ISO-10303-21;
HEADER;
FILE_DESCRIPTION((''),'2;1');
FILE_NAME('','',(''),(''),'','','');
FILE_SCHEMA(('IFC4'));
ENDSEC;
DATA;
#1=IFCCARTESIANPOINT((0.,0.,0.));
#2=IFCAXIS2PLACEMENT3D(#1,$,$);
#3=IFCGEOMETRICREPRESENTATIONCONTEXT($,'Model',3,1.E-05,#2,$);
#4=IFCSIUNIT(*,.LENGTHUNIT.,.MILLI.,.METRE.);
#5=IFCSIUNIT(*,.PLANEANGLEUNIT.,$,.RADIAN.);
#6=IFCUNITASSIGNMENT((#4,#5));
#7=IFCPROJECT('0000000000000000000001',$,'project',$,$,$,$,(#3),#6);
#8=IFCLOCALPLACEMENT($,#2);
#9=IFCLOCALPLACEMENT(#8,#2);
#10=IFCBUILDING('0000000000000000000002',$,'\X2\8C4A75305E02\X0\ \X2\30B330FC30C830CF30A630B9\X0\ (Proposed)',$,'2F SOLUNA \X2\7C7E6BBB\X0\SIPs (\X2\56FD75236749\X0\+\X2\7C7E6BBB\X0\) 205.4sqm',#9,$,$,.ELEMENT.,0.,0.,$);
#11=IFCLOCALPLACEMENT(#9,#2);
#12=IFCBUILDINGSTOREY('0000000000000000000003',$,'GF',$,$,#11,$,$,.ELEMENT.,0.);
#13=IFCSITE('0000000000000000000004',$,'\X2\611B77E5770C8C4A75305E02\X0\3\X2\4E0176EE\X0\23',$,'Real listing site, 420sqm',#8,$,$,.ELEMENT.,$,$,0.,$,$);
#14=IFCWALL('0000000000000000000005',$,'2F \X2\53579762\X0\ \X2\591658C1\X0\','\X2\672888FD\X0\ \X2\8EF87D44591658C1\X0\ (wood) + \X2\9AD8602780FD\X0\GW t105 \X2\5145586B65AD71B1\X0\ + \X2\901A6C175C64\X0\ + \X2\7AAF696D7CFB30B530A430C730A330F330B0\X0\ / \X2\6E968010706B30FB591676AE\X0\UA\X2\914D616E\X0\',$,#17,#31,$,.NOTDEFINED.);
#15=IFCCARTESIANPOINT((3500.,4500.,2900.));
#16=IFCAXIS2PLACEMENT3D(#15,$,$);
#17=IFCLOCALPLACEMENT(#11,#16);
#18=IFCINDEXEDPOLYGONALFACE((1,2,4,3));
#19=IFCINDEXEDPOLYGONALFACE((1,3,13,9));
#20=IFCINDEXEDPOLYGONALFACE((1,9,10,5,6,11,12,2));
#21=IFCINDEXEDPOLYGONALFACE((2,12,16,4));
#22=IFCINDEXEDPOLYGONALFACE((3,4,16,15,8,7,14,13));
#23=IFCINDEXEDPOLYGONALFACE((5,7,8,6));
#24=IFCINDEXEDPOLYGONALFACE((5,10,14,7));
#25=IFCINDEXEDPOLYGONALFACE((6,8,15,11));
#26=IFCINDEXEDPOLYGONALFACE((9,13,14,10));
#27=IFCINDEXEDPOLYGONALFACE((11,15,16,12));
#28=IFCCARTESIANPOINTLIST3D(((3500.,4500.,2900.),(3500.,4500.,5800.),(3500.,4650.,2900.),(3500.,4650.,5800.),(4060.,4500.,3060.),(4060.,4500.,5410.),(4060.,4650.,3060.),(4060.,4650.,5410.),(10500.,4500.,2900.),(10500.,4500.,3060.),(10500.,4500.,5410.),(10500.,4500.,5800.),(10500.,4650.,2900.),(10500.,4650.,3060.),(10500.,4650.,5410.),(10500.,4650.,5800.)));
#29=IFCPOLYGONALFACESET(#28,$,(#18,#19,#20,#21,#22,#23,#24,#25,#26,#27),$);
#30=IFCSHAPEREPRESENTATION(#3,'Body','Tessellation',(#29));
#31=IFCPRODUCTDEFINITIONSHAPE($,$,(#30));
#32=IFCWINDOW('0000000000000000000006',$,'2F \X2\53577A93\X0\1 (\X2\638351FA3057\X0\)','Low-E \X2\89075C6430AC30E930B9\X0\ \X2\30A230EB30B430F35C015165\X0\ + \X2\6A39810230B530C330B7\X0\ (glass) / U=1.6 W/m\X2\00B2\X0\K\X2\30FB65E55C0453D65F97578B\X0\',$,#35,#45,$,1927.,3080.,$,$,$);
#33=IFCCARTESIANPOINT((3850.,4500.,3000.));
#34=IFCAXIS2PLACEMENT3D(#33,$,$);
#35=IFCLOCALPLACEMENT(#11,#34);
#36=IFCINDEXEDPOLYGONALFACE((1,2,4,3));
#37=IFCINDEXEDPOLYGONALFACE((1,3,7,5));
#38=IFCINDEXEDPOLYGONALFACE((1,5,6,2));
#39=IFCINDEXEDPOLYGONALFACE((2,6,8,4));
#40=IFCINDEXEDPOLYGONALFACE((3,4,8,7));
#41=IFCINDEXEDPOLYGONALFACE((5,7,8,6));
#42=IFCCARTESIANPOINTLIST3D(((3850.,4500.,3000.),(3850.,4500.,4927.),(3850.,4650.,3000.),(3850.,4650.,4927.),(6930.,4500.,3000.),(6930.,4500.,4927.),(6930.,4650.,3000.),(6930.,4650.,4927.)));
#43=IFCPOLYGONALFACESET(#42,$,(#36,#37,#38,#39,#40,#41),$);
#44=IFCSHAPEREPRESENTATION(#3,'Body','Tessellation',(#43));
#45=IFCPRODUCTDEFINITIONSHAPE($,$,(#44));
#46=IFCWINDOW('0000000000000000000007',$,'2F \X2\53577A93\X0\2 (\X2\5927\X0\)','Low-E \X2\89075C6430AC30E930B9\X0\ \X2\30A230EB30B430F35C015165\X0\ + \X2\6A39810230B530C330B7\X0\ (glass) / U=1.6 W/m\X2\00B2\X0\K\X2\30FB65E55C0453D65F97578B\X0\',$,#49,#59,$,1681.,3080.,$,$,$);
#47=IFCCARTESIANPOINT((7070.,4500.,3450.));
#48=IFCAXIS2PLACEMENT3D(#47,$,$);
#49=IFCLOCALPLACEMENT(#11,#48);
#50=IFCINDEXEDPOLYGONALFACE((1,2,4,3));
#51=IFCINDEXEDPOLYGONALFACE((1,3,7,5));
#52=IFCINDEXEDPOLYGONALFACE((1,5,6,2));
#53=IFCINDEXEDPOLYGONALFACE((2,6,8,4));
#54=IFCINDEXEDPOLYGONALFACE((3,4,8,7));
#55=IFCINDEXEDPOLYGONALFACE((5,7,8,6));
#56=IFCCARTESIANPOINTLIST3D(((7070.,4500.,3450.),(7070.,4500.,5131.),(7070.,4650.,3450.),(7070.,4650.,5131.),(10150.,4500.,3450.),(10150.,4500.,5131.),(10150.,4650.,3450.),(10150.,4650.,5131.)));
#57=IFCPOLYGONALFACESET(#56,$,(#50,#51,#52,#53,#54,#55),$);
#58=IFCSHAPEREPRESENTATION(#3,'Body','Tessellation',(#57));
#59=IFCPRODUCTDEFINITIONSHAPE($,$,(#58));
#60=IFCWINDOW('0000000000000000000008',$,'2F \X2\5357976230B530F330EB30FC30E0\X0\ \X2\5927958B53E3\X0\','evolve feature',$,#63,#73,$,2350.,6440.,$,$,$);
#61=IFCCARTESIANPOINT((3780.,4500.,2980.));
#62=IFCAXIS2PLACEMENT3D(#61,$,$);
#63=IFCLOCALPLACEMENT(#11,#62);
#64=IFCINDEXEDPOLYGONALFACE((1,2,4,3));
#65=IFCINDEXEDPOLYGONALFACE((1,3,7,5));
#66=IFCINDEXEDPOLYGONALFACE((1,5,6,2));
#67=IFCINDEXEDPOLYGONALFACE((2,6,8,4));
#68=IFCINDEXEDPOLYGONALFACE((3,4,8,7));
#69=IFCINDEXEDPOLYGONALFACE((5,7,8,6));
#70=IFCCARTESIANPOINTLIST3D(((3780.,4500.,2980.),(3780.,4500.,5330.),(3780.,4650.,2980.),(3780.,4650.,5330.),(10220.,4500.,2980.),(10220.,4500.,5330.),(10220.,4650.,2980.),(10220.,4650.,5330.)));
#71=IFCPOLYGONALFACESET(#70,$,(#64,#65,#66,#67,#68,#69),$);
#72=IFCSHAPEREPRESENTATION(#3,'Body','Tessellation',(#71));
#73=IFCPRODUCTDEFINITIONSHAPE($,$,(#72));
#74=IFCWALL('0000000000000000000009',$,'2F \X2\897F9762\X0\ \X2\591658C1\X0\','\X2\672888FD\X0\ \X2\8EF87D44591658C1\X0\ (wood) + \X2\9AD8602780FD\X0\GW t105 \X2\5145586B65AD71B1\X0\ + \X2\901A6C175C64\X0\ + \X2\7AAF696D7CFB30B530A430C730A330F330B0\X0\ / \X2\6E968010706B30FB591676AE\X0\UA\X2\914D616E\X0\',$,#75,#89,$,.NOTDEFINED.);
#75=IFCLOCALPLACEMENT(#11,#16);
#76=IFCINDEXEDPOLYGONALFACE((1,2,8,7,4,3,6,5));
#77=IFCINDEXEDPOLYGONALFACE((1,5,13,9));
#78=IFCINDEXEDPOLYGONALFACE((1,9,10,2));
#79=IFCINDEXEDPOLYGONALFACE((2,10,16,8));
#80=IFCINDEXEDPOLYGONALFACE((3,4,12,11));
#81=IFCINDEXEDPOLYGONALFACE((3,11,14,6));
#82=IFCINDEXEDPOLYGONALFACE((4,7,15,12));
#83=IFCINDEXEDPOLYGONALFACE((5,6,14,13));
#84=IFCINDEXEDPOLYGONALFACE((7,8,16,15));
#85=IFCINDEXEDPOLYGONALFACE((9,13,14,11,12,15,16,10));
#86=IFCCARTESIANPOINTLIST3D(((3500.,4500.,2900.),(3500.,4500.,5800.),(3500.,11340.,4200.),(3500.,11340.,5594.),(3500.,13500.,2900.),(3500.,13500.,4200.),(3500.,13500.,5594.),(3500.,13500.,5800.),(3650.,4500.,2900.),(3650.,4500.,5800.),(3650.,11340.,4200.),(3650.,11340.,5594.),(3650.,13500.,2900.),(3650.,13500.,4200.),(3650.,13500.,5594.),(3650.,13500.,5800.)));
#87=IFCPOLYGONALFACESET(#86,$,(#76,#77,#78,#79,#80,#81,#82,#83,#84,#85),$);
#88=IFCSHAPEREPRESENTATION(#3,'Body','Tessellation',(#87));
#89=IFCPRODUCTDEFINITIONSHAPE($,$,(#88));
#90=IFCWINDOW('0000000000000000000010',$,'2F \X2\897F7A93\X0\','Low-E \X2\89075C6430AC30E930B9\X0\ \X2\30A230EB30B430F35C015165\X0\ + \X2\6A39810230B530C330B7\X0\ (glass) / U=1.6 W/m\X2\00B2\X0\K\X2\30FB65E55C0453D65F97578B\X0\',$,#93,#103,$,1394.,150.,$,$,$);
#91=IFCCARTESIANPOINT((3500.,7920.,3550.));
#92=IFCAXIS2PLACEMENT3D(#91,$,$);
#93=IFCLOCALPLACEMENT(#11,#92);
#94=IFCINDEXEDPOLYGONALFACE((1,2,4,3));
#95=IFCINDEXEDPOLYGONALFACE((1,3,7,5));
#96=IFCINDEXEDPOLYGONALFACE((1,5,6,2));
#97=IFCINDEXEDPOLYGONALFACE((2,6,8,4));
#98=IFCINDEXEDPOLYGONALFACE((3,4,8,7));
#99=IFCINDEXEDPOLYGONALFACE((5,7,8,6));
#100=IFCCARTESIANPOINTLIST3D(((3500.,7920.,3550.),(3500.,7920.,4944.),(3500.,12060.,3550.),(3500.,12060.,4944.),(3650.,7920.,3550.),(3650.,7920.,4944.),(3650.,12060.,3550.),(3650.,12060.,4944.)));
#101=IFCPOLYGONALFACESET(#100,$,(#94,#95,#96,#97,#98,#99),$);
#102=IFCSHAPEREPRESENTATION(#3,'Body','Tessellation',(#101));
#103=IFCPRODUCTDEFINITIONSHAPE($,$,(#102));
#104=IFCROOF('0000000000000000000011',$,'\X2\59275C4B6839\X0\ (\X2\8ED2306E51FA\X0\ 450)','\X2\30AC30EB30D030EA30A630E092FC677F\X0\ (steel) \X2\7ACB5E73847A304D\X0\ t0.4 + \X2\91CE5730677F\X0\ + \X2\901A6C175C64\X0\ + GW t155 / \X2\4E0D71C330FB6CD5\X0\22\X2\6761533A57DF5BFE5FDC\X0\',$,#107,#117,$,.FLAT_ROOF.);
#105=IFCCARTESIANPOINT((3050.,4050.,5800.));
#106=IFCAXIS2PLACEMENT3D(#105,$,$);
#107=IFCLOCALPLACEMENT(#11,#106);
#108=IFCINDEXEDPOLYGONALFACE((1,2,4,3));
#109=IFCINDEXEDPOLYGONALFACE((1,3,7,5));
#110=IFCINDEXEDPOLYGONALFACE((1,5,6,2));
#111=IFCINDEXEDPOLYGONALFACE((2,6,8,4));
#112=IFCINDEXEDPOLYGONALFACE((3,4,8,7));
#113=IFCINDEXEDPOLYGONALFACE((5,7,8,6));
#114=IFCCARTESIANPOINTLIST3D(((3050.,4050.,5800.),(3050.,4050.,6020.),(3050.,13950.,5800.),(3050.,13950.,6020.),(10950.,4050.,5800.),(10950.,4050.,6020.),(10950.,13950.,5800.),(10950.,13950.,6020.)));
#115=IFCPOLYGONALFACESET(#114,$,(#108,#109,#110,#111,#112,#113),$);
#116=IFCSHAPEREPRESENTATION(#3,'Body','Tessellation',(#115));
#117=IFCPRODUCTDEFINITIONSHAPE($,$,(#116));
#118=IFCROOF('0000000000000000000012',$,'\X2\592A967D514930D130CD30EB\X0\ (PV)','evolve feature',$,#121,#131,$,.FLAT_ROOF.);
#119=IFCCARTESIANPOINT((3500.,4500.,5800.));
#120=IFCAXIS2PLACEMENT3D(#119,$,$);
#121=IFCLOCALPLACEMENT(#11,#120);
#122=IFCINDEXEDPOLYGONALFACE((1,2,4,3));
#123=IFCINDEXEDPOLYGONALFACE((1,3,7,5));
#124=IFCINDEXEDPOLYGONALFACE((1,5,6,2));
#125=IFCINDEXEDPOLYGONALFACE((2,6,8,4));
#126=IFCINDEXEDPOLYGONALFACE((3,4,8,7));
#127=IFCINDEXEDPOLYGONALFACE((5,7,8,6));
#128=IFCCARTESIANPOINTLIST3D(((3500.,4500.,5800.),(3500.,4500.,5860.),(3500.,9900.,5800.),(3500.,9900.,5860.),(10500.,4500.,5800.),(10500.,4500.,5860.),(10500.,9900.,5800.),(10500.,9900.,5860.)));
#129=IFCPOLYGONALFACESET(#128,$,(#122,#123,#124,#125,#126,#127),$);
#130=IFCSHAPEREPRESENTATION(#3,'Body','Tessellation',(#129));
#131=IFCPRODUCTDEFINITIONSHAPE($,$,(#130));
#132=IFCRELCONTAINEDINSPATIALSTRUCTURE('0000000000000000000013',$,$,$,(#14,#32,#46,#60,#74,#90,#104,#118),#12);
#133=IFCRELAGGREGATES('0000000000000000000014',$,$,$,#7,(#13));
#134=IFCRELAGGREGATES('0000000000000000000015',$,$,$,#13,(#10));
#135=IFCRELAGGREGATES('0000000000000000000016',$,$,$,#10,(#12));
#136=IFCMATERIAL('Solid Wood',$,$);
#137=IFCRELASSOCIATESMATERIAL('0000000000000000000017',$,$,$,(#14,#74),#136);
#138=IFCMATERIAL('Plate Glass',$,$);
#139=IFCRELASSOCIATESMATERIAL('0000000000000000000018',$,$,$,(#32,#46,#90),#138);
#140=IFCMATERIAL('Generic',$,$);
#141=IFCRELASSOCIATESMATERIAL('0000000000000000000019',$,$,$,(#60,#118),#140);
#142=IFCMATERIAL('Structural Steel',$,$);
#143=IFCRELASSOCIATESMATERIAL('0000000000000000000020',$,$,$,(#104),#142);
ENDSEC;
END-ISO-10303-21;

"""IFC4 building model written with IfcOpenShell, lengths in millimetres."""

from ifc_helpers import new_model, si_unit, frame, frame_2d, origin, place, context, project, spatial, rectangle, extrude, material, element, fill, save


model = new_model("IFC4")

# Units and contexts
model_context = context("Model", 3, precision=1e-05, world=origin())
ifc_project = project(units=[si_unit("LENGTHUNIT", "METRE", prefix="MILLI"), si_unit("PLANEANGLEUNIT", "RADIAN")], contexts=[model_context])

# Site, building, storey
site_placement = place(None, origin())
site = spatial("IfcSite", under=ifc_project, at=site_placement, Name="愛知県豊田市3丁目23", ObjectType="Real listing site, 420sqm", CompositionType="ELEMENT", RefElevation=0.0)
building_placement = place(site_placement, origin())
building = spatial("IfcBuilding", under=site, at=building_placement, Name="豊田市 コートハウス (Proposed)", ObjectType="2F SOLUNA 籾殻SIPs (国産杉+籾殻) 205.4sqm", CompositionType="ELEMENT", ElevationOfRefHeight=0.0, ElevationOfTerrain=0.0)
storey_placement = place(building_placement, origin())
storey = spatial("IfcBuildingStorey", under=building, at=storey_placement, Name="GF", CompositionType="ELEMENT", Elevation=0.0)

# Shared definitions
ifc_material_1 = material(Name="Solid Wood")
ifc_material_2 = material(Name="Generic")

# Shared definitions
ifc_material_3 = material(Name="Plate Glass")

# Wall, openings, windows
wall_1_placement = place(storey_placement, frame((3500.0, 4500.0, 2900.0)))
wall_1 = element("IfcWall", 1, at=wall_1_placement, inside=storey, material=ifc_material_1, Name="2F 南面 外壁", Description="木製 軸組外壁 (wood) + 高性能GW t105 充填断熱 + 通気層 + 窯業系サイディング / 準耐火・外皮UA配慮", PredefinedType="NOTDEFINED", context=model_context, shape_type="SweptSolid", body=[
    extrude(rectangle(XDim=7000.0, YDim=150.0, at=frame_2d((3500.0, 75.0))), frame((3500.0, 4500.0, 2900.0)), (0.0, 0.0, 1.0), 2900.0),
])
opening_1_placement = place(storey_placement, frame((3850.0, 4500.0, 3000.0)))
opening_1 = element("IfcOpeningElement", 2, at=opening_1_placement, cuts=wall_1, PredefinedType="NOTDEFINED", context=model_context, shape_type="SweptSolid", body=[
    extrude(rectangle(XDim=3080.0, YDim=150.0, at=frame_2d((1540.0, 75.0))), frame((3850.0, 4500.0, 3000.0)), (0.0, 0.0, 1.0), 1927.0),
])
opening_2_placement = place(storey_placement, frame((7070.0, 4500.0, 3450.0)))
opening_2 = element("IfcOpeningElement", 3, at=opening_2_placement, cuts=wall_1, PredefinedType="NOTDEFINED", context=model_context, shape_type="SweptSolid", body=[
    extrude(rectangle(XDim=3080.0, YDim=150.0, at=frame_2d((1540.0, 75.0))), frame((7070.0, 4500.0, 3450.0)), (0.0, 0.0, 1.0), 1681.0),
])
opening_3_placement = place(storey_placement, frame((3780.0, 4500.0, 2980.0)))
opening_3 = element("IfcOpeningElement", 4, at=opening_3_placement, cuts=wall_1, PredefinedType="NOTDEFINED", context=model_context, shape_type="SweptSolid", body=[
    extrude(rectangle(XDim=6440.0, YDim=150.0, at=frame_2d((3220.0, 75.0))), frame((3780.0, 4500.0, 2980.0)), (0.0, 0.0, 1.0), 2350.0),
])
window_1_placement = place(storey_placement, frame((3850.0, 4500.0, 3000.0)))
window_1 = element("IfcWindow", 5, at=window_1_placement, inside=storey, material=ifc_material_3, Name="2F 南窓1 (掃出し)", Description="Low-E 複層ガラス アルゴン封入 + 樹脂サッシ (glass) / U=1.6 W/m²K・日射取得型", OverallHeight=1927.0, OverallWidth=3080.0, context=model_context, shape_type="SweptSolid", body=[
    extrude(rectangle(XDim=3080.0, YDim=150.0, at=frame_2d((1540.0, 75.0))), frame((3850.0, 4500.0, 3000.0)), (0.0, 0.0, 1.0), 1927.0),
])
fill(opening_1, window_1)
window_2_placement = place(storey_placement, frame((7070.0, 4500.0, 3450.0)))
window_2 = element("IfcWindow", 6, at=window_2_placement, inside=storey, material=ifc_material_3, Name="2F 南窓2 (大)", Description="Low-E 複層ガラス アルゴン封入 + 樹脂サッシ (glass) / U=1.6 W/m²K・日射取得型", OverallHeight=1681.0, OverallWidth=3080.0, context=model_context, shape_type="SweptSolid", body=[
    extrude(rectangle(XDim=3080.0, YDim=150.0, at=frame_2d((1540.0, 75.0))), frame((7070.0, 4500.0, 3450.0)), (0.0, 0.0, 1.0), 1681.0),
])
fill(opening_2, window_2)
window_3_placement = place(storey_placement, frame((3780.0, 4500.0, 2980.0)))
window_3 = element("IfcWindow", 7, at=window_3_placement, inside=storey, material=ifc_material_2, Name="2F 南面サンルーム 大開口", Description="evolve feature", OverallHeight=2350.0, OverallWidth=6440.0, context=model_context, shape_type="SweptSolid", body=[
    extrude(rectangle(XDim=6440.0, YDim=150.0, at=frame_2d((3220.0, 75.0))), frame((3780.0, 4500.0, 2980.0)), (0.0, 0.0, 1.0), 2350.0),
])
fill(opening_3, window_3)

# Wall, opening, window
wall_2_placement = place(storey_placement, frame((3500.0, 4500.0, 2900.0)))
wall_2 = element("IfcWall", 8, at=wall_2_placement, inside=storey, material=ifc_material_1, Name="2F 西面 外壁", Description="木製 軸組外壁 (wood) + 高性能GW t105 充填断熱 + 通気層 + 窯業系サイディング / 準耐火・外皮UA配慮", PredefinedType="NOTDEFINED", context=model_context, shape_type="SweptSolid", body=[
    extrude(rectangle(XDim=150.0, YDim=9000.0, at=frame_2d((75.0, 4500.0))), frame((3500.0, 4500.0, 2900.0)), (0.0, 0.0, 1.0), 2900.0),
])
opening_4_placement = place(storey_placement, frame((3500.0, 7920.0, 3550.0)))
opening_4 = element("IfcOpeningElement", 9, at=opening_4_placement, cuts=wall_2, PredefinedType="NOTDEFINED", context=model_context, shape_type="SweptSolid", body=[
    extrude(rectangle(XDim=150.0, YDim=4140.0, at=frame_2d((75.0, 2070.0))), frame((3500.0, 7920.0, 3550.0)), (0.0, 0.0, 1.0), 1394.0),
])
window_4_placement = place(storey_placement, frame((3500.0, 7920.0, 3550.0)))
window_4 = element("IfcWindow", 10, at=window_4_placement, inside=storey, material=ifc_material_3, Name="2F 西窓", Description="Low-E 複層ガラス アルゴン封入 + 樹脂サッシ (glass) / U=1.6 W/m²K・日射取得型", OverallHeight=1394.0, OverallWidth=150.0, context=model_context, shape_type="SweptSolid", body=[
    extrude(rectangle(XDim=150.0, YDim=4140.0, at=frame_2d((75.0, 2070.0))), frame((3500.0, 7920.0, 3550.0)), (0.0, 0.0, 1.0), 1394.0),
])
fill(opening_4, window_4)

# Roofs
ifc_material_4 = material(Name="Structural Steel")
roof_1_placement = place(storey_placement, frame((3050.0, 4050.0, 5800.0)))
element("IfcRoof", 11, at=roof_1_placement, inside=storey, material=ifc_material_4, Name="大屋根 (軒の出 450)", Description="ガルバリウム鋼板 (steel) 立平葺き t0.4 + 野地板 + 通気層 + GW t155 / 不燃・法22条区域対応", PredefinedType="FLAT_ROOF", context=model_context, shape_type="SweptSolid", body=[
    extrude(rectangle(XDim=7900.0, YDim=9900.0, at=frame_2d((3950.0, 4950.0))), frame((3050.0, 4050.0, 5800.0)), (0.0, 0.0, 1.0), 220.0),
])
roof_2_placement = place(storey_placement, frame((3500.0, 4500.0, 5800.0)))
element("IfcRoof", 12, at=roof_2_placement, inside=storey, material=ifc_material_2, Name="太陽光パネル (PV)", Description="evolve feature", PredefinedType="FLAT_ROOF", context=model_context, shape_type="SweptSolid", body=[
    extrude(rectangle(XDim=7000.0, YDim=5400.0, at=frame_2d((3500.0, 2700.0))), frame((3500.0, 4500.0, 5800.0)), (0.0, 0.0, 1.0), 60.0),
])

save(model, "model.ifc")
